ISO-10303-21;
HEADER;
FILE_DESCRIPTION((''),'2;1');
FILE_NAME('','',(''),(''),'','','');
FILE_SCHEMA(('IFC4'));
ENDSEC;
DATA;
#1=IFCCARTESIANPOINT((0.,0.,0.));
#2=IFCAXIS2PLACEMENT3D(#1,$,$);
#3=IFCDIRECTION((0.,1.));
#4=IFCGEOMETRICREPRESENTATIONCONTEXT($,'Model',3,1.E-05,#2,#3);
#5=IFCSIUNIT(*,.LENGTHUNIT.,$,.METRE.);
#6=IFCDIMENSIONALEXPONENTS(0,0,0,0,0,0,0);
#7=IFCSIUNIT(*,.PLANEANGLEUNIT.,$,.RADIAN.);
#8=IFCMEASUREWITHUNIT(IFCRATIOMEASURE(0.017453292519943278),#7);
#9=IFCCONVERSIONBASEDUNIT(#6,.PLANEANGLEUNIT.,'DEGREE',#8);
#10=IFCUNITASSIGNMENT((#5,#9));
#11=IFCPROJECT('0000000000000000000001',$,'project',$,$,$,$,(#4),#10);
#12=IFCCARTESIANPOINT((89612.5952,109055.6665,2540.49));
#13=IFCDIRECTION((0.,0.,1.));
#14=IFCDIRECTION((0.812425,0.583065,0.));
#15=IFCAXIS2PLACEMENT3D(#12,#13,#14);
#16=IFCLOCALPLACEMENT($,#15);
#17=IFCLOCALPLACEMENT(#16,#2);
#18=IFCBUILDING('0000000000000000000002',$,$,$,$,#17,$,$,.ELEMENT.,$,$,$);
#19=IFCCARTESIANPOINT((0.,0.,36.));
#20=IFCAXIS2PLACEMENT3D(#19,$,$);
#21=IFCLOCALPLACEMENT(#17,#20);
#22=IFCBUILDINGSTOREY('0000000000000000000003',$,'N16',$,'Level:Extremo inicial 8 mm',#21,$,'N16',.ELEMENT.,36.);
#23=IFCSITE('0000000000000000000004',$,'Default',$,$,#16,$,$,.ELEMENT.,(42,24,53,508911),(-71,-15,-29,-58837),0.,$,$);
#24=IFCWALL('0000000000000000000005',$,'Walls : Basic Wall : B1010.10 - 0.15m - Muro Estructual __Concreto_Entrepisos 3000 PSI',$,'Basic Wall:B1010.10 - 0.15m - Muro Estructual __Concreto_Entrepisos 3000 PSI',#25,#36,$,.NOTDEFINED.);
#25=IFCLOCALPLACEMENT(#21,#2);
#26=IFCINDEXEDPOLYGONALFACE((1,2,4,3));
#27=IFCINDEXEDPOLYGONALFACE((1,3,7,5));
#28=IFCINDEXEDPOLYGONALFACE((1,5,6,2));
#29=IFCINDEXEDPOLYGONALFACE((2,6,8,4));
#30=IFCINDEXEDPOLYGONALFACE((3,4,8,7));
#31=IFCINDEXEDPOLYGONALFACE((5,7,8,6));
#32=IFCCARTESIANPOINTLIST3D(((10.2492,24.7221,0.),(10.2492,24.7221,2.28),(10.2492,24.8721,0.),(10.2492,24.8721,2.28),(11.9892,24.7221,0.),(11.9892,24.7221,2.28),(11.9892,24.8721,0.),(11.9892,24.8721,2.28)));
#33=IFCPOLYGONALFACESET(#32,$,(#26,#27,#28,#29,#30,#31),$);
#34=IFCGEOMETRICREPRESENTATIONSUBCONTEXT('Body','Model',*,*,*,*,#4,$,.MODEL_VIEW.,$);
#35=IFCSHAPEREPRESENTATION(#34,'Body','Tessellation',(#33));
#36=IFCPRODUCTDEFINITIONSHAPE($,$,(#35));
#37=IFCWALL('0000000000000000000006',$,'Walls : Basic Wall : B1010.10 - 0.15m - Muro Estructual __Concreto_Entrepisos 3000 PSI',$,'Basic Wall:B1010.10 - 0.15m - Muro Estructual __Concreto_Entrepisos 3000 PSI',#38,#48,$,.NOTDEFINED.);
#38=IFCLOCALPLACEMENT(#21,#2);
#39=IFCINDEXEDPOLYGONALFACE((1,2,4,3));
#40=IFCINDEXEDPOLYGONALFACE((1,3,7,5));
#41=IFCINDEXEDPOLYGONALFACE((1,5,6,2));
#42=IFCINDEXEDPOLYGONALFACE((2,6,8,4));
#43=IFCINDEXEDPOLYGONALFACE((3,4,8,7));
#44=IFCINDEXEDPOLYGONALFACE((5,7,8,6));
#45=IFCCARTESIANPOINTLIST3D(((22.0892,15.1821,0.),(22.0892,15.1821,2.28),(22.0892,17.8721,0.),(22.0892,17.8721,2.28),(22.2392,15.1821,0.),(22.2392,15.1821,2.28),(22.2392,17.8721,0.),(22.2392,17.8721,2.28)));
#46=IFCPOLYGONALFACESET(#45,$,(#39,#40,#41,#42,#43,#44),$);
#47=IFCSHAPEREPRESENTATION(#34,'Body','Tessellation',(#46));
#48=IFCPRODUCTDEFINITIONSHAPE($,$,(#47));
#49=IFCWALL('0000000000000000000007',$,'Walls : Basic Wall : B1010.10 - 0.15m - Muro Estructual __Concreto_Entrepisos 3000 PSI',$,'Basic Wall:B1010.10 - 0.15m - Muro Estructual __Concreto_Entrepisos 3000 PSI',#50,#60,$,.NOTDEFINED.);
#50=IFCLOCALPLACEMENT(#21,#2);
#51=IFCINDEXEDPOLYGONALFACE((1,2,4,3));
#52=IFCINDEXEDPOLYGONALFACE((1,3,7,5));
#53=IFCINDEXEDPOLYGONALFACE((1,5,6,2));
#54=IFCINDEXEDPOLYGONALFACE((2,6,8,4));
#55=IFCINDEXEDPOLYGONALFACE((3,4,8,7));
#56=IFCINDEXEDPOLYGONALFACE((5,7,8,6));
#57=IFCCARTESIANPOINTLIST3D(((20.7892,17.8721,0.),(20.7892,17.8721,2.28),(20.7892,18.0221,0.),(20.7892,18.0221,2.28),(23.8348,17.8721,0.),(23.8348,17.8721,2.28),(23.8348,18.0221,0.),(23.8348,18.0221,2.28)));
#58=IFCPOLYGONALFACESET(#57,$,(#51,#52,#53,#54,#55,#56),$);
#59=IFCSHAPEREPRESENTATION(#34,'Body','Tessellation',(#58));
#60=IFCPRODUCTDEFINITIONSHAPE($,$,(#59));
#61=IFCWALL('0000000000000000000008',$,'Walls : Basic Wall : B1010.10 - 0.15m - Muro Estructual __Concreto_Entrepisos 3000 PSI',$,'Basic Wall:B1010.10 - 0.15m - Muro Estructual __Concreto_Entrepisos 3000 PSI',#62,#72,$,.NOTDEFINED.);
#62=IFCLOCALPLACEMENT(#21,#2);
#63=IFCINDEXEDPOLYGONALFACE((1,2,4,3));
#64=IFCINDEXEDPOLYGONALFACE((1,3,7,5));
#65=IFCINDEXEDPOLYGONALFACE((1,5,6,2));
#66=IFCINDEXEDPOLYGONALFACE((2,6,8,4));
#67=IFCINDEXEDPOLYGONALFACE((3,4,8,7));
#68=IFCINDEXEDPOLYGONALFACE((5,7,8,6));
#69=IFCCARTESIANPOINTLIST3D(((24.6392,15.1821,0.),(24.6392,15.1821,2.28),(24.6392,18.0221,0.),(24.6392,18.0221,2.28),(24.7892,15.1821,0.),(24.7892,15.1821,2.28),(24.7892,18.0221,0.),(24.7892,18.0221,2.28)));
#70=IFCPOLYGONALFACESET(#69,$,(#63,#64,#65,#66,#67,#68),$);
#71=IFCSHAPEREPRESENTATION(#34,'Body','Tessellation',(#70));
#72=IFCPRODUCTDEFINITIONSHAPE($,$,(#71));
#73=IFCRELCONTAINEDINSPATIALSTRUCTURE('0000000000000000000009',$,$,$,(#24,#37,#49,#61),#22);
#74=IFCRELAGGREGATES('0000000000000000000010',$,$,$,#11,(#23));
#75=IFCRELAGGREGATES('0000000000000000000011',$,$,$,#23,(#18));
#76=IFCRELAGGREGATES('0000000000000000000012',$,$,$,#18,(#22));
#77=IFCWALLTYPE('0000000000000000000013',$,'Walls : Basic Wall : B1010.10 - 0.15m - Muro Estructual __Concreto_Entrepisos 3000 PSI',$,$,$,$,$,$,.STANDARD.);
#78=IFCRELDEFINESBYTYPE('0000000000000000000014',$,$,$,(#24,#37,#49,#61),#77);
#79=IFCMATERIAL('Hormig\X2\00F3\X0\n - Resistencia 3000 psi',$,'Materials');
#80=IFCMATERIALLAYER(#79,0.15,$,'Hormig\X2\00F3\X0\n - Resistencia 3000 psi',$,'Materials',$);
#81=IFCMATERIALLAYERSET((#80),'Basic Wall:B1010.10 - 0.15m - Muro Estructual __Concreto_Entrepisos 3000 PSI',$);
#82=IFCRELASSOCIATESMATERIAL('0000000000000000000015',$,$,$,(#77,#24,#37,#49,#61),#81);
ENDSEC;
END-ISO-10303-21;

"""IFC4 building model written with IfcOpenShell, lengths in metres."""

from ifc_helpers import new_model, entity, si_unit, converted_unit, direction, frame, frame_2d, origin, place, context, subcontext, project, spatial, rectangle, extrude, material, layer, layer_set, layer_usage, type_object, element, save


model = new_model("IFC4")

# Units and contexts
model_context = context("Model", 3, precision=1e-05, world=origin(), true_north=direction((0.0, 1.0)))
body_context = subcontext(model_context, "Body", "Model", "MODEL_VIEW")
ifc_project = project(units=[si_unit("LENGTHUNIT", "METRE"), converted_unit("PLANEANGLEUNIT", "DEGREE", entity("IfcRatioMeasure", 0.017453292519943278), si_unit("PLANEANGLEUNIT", "RADIAN"), dimensions=[0, 0, 0, 0, 0, 0, 0])], contexts=[model_context])

# Site, building, storey
site_placement = place(None, frame((89612.5952, 109055.6665, 2540.49), z_axis=(0.0, 0.0, 1.0), x_axis=(0.812425, 0.583065, 0.0)))
site = spatial("IfcSite", under=ifc_project, at=site_placement, Name="Default", CompositionType="ELEMENT", RefLatitude=(42, 24, 53, 508911), RefLongitude=(-71, -15, -29, -58837), RefElevation=0.0)
building_placement = place(site_placement, origin())
building = spatial("IfcBuilding", under=site, at=building_placement, CompositionType="ELEMENT")
storey_placement = place(building_placement, frame((0.0, 0.0, 36.0)))
storey = spatial("IfcBuildingStorey", under=building, at=storey_placement, Name="N16", ObjectType="Level:Extremo inicial 8 mm", LongName="N16", CompositionType="ELEMENT", Elevation=36.0)

# Walls
ifc_material = material(Name="Hormigón - Resistencia 3000 psi", Category="Materials")
ifc_layer_1 = layer(ifc_material, 0.15, Name="Hormigón - Resistencia 3000 psi", Category="Materials")
ifc_layer_set_1 = layer_set([ifc_layer_1], Name="Basic Wall:B1010.10 - 0.15m - Muro Estructual __Concreto_Entrepisos 3000 PSI")
wall_type_1 = type_object("IfcWallType", Name="Walls : Basic Wall : B1010.10 - 0.15m - Muro Estructual __Concreto_Entrepisos 3000 PSI", PredefinedType="STANDARD", material=ifc_layer_set_1)
ifc_layer_usage_1 = layer_usage(ifc_layer_set_1, "AXIS2", "POSITIVE", -0.075)
wall_1_placement = place(storey_placement, frame((11.9892, 24.7971, 0.0), z_axis=(0.0, 0.0, 1.0), x_axis=(-1.0, 0.0, 0.0)))
element("IfcWall", 1, at=wall_1_placement, inside=storey, type_object=wall_type_1, material=ifc_layer_usage_1, Name="Walls : Basic Wall : B1010.10 - 0.15m - Muro Estructual __Concreto_Entrepisos 3000 PSI", ObjectType="Basic Wall:B1010.10 - 0.15m - Muro Estructual __Concreto_Entrepisos 3000 PSI", PredefinedType="NOTDEFINED", context=body_context, shape_type="SweptSolid", body=[
    extrude(rectangle(XDim=1.74, YDim=0.15, at=frame_2d((0.87, 0.0), x_axis=(-1.0, 0.0))), origin(), (0.0, 0.0, 1.0), 2.28),
])
ifc_layer_usage_2 = layer_usage(ifc_layer_set_1, "AXIS2", "POSITIVE", -0.075)
wall_2_placement = place(storey_placement, frame((22.1642, 15.1821, 0.0), z_axis=(0.0, 0.0, 1.0), x_axis=(0.0, 1.0, 0.0)))
element("IfcWall", 2, at=wall_2_placement, inside=storey, type_object=wall_type_1, material=ifc_layer_usage_2, Name="Walls : Basic Wall : B1010.10 - 0.15m - Muro Estructual __Concreto_Entrepisos 3000 PSI", ObjectType="Basic Wall:B1010.10 - 0.15m - Muro Estructual __Concreto_Entrepisos 3000 PSI", PredefinedType="NOTDEFINED", context=body_context, shape_type="SweptSolid", body=[
    extrude(rectangle(XDim=2.69, YDim=0.15, at=frame_2d((1.345, 0.0), x_axis=(-1.0, 0.0))), origin(), (0.0, 0.0, 1.0), 2.28),
])
ifc_layer_usage_3 = layer_usage(ifc_layer_set_1, "AXIS2", "POSITIVE", -0.075)
wall_3_placement = place(storey_placement, frame((20.7892, 17.9471, 0.0)))
element("IfcWall", 3, at=wall_3_placement, inside=storey, type_object=wall_type_1, material=ifc_layer_usage_3, Name="Walls : Basic Wall : B1010.10 - 0.15m - Muro Estructual __Concreto_Entrepisos 3000 PSI", ObjectType="Basic Wall:B1010.10 - 0.15m - Muro Estructual __Concreto_Entrepisos 3000 PSI", PredefinedType="NOTDEFINED", context=body_context, shape_type="SweptSolid", body=[
    extrude(rectangle(XDim=3.0455, YDim=0.15, at=frame_2d((1.5228, 0.0), x_axis=(-1.0, 0.0))), origin(), (0.0, 0.0, 1.0), 2.28),
])
ifc_layer_usage_4 = layer_usage(ifc_layer_set_1, "AXIS2", "POSITIVE", -0.075)
wall_4_placement = place(storey_placement, frame((24.7142, 15.1821, 0.0), z_axis=(0.0, 0.0, 1.0), x_axis=(0.0, 1.0, 0.0)))
element("IfcWall", 4, at=wall_4_placement, inside=storey, type_object=wall_type_1, material=ifc_layer_usage_4, Name="Walls : Basic Wall : B1010.10 - 0.15m - Muro Estructual __Concreto_Entrepisos 3000 PSI", ObjectType="Basic Wall:B1010.10 - 0.15m - Muro Estructual __Concreto_Entrepisos 3000 PSI", PredefinedType="NOTDEFINED", context=body_context, shape_type="SweptSolid", body=[
    extrude(rectangle(XDim=2.84, YDim=0.15, at=frame_2d((1.42, 0.0), x_axis=(-1.0, 0.0))), origin(), (0.0, 0.0, 1.0), 2.28),
])

save(model, "model.ifc")
